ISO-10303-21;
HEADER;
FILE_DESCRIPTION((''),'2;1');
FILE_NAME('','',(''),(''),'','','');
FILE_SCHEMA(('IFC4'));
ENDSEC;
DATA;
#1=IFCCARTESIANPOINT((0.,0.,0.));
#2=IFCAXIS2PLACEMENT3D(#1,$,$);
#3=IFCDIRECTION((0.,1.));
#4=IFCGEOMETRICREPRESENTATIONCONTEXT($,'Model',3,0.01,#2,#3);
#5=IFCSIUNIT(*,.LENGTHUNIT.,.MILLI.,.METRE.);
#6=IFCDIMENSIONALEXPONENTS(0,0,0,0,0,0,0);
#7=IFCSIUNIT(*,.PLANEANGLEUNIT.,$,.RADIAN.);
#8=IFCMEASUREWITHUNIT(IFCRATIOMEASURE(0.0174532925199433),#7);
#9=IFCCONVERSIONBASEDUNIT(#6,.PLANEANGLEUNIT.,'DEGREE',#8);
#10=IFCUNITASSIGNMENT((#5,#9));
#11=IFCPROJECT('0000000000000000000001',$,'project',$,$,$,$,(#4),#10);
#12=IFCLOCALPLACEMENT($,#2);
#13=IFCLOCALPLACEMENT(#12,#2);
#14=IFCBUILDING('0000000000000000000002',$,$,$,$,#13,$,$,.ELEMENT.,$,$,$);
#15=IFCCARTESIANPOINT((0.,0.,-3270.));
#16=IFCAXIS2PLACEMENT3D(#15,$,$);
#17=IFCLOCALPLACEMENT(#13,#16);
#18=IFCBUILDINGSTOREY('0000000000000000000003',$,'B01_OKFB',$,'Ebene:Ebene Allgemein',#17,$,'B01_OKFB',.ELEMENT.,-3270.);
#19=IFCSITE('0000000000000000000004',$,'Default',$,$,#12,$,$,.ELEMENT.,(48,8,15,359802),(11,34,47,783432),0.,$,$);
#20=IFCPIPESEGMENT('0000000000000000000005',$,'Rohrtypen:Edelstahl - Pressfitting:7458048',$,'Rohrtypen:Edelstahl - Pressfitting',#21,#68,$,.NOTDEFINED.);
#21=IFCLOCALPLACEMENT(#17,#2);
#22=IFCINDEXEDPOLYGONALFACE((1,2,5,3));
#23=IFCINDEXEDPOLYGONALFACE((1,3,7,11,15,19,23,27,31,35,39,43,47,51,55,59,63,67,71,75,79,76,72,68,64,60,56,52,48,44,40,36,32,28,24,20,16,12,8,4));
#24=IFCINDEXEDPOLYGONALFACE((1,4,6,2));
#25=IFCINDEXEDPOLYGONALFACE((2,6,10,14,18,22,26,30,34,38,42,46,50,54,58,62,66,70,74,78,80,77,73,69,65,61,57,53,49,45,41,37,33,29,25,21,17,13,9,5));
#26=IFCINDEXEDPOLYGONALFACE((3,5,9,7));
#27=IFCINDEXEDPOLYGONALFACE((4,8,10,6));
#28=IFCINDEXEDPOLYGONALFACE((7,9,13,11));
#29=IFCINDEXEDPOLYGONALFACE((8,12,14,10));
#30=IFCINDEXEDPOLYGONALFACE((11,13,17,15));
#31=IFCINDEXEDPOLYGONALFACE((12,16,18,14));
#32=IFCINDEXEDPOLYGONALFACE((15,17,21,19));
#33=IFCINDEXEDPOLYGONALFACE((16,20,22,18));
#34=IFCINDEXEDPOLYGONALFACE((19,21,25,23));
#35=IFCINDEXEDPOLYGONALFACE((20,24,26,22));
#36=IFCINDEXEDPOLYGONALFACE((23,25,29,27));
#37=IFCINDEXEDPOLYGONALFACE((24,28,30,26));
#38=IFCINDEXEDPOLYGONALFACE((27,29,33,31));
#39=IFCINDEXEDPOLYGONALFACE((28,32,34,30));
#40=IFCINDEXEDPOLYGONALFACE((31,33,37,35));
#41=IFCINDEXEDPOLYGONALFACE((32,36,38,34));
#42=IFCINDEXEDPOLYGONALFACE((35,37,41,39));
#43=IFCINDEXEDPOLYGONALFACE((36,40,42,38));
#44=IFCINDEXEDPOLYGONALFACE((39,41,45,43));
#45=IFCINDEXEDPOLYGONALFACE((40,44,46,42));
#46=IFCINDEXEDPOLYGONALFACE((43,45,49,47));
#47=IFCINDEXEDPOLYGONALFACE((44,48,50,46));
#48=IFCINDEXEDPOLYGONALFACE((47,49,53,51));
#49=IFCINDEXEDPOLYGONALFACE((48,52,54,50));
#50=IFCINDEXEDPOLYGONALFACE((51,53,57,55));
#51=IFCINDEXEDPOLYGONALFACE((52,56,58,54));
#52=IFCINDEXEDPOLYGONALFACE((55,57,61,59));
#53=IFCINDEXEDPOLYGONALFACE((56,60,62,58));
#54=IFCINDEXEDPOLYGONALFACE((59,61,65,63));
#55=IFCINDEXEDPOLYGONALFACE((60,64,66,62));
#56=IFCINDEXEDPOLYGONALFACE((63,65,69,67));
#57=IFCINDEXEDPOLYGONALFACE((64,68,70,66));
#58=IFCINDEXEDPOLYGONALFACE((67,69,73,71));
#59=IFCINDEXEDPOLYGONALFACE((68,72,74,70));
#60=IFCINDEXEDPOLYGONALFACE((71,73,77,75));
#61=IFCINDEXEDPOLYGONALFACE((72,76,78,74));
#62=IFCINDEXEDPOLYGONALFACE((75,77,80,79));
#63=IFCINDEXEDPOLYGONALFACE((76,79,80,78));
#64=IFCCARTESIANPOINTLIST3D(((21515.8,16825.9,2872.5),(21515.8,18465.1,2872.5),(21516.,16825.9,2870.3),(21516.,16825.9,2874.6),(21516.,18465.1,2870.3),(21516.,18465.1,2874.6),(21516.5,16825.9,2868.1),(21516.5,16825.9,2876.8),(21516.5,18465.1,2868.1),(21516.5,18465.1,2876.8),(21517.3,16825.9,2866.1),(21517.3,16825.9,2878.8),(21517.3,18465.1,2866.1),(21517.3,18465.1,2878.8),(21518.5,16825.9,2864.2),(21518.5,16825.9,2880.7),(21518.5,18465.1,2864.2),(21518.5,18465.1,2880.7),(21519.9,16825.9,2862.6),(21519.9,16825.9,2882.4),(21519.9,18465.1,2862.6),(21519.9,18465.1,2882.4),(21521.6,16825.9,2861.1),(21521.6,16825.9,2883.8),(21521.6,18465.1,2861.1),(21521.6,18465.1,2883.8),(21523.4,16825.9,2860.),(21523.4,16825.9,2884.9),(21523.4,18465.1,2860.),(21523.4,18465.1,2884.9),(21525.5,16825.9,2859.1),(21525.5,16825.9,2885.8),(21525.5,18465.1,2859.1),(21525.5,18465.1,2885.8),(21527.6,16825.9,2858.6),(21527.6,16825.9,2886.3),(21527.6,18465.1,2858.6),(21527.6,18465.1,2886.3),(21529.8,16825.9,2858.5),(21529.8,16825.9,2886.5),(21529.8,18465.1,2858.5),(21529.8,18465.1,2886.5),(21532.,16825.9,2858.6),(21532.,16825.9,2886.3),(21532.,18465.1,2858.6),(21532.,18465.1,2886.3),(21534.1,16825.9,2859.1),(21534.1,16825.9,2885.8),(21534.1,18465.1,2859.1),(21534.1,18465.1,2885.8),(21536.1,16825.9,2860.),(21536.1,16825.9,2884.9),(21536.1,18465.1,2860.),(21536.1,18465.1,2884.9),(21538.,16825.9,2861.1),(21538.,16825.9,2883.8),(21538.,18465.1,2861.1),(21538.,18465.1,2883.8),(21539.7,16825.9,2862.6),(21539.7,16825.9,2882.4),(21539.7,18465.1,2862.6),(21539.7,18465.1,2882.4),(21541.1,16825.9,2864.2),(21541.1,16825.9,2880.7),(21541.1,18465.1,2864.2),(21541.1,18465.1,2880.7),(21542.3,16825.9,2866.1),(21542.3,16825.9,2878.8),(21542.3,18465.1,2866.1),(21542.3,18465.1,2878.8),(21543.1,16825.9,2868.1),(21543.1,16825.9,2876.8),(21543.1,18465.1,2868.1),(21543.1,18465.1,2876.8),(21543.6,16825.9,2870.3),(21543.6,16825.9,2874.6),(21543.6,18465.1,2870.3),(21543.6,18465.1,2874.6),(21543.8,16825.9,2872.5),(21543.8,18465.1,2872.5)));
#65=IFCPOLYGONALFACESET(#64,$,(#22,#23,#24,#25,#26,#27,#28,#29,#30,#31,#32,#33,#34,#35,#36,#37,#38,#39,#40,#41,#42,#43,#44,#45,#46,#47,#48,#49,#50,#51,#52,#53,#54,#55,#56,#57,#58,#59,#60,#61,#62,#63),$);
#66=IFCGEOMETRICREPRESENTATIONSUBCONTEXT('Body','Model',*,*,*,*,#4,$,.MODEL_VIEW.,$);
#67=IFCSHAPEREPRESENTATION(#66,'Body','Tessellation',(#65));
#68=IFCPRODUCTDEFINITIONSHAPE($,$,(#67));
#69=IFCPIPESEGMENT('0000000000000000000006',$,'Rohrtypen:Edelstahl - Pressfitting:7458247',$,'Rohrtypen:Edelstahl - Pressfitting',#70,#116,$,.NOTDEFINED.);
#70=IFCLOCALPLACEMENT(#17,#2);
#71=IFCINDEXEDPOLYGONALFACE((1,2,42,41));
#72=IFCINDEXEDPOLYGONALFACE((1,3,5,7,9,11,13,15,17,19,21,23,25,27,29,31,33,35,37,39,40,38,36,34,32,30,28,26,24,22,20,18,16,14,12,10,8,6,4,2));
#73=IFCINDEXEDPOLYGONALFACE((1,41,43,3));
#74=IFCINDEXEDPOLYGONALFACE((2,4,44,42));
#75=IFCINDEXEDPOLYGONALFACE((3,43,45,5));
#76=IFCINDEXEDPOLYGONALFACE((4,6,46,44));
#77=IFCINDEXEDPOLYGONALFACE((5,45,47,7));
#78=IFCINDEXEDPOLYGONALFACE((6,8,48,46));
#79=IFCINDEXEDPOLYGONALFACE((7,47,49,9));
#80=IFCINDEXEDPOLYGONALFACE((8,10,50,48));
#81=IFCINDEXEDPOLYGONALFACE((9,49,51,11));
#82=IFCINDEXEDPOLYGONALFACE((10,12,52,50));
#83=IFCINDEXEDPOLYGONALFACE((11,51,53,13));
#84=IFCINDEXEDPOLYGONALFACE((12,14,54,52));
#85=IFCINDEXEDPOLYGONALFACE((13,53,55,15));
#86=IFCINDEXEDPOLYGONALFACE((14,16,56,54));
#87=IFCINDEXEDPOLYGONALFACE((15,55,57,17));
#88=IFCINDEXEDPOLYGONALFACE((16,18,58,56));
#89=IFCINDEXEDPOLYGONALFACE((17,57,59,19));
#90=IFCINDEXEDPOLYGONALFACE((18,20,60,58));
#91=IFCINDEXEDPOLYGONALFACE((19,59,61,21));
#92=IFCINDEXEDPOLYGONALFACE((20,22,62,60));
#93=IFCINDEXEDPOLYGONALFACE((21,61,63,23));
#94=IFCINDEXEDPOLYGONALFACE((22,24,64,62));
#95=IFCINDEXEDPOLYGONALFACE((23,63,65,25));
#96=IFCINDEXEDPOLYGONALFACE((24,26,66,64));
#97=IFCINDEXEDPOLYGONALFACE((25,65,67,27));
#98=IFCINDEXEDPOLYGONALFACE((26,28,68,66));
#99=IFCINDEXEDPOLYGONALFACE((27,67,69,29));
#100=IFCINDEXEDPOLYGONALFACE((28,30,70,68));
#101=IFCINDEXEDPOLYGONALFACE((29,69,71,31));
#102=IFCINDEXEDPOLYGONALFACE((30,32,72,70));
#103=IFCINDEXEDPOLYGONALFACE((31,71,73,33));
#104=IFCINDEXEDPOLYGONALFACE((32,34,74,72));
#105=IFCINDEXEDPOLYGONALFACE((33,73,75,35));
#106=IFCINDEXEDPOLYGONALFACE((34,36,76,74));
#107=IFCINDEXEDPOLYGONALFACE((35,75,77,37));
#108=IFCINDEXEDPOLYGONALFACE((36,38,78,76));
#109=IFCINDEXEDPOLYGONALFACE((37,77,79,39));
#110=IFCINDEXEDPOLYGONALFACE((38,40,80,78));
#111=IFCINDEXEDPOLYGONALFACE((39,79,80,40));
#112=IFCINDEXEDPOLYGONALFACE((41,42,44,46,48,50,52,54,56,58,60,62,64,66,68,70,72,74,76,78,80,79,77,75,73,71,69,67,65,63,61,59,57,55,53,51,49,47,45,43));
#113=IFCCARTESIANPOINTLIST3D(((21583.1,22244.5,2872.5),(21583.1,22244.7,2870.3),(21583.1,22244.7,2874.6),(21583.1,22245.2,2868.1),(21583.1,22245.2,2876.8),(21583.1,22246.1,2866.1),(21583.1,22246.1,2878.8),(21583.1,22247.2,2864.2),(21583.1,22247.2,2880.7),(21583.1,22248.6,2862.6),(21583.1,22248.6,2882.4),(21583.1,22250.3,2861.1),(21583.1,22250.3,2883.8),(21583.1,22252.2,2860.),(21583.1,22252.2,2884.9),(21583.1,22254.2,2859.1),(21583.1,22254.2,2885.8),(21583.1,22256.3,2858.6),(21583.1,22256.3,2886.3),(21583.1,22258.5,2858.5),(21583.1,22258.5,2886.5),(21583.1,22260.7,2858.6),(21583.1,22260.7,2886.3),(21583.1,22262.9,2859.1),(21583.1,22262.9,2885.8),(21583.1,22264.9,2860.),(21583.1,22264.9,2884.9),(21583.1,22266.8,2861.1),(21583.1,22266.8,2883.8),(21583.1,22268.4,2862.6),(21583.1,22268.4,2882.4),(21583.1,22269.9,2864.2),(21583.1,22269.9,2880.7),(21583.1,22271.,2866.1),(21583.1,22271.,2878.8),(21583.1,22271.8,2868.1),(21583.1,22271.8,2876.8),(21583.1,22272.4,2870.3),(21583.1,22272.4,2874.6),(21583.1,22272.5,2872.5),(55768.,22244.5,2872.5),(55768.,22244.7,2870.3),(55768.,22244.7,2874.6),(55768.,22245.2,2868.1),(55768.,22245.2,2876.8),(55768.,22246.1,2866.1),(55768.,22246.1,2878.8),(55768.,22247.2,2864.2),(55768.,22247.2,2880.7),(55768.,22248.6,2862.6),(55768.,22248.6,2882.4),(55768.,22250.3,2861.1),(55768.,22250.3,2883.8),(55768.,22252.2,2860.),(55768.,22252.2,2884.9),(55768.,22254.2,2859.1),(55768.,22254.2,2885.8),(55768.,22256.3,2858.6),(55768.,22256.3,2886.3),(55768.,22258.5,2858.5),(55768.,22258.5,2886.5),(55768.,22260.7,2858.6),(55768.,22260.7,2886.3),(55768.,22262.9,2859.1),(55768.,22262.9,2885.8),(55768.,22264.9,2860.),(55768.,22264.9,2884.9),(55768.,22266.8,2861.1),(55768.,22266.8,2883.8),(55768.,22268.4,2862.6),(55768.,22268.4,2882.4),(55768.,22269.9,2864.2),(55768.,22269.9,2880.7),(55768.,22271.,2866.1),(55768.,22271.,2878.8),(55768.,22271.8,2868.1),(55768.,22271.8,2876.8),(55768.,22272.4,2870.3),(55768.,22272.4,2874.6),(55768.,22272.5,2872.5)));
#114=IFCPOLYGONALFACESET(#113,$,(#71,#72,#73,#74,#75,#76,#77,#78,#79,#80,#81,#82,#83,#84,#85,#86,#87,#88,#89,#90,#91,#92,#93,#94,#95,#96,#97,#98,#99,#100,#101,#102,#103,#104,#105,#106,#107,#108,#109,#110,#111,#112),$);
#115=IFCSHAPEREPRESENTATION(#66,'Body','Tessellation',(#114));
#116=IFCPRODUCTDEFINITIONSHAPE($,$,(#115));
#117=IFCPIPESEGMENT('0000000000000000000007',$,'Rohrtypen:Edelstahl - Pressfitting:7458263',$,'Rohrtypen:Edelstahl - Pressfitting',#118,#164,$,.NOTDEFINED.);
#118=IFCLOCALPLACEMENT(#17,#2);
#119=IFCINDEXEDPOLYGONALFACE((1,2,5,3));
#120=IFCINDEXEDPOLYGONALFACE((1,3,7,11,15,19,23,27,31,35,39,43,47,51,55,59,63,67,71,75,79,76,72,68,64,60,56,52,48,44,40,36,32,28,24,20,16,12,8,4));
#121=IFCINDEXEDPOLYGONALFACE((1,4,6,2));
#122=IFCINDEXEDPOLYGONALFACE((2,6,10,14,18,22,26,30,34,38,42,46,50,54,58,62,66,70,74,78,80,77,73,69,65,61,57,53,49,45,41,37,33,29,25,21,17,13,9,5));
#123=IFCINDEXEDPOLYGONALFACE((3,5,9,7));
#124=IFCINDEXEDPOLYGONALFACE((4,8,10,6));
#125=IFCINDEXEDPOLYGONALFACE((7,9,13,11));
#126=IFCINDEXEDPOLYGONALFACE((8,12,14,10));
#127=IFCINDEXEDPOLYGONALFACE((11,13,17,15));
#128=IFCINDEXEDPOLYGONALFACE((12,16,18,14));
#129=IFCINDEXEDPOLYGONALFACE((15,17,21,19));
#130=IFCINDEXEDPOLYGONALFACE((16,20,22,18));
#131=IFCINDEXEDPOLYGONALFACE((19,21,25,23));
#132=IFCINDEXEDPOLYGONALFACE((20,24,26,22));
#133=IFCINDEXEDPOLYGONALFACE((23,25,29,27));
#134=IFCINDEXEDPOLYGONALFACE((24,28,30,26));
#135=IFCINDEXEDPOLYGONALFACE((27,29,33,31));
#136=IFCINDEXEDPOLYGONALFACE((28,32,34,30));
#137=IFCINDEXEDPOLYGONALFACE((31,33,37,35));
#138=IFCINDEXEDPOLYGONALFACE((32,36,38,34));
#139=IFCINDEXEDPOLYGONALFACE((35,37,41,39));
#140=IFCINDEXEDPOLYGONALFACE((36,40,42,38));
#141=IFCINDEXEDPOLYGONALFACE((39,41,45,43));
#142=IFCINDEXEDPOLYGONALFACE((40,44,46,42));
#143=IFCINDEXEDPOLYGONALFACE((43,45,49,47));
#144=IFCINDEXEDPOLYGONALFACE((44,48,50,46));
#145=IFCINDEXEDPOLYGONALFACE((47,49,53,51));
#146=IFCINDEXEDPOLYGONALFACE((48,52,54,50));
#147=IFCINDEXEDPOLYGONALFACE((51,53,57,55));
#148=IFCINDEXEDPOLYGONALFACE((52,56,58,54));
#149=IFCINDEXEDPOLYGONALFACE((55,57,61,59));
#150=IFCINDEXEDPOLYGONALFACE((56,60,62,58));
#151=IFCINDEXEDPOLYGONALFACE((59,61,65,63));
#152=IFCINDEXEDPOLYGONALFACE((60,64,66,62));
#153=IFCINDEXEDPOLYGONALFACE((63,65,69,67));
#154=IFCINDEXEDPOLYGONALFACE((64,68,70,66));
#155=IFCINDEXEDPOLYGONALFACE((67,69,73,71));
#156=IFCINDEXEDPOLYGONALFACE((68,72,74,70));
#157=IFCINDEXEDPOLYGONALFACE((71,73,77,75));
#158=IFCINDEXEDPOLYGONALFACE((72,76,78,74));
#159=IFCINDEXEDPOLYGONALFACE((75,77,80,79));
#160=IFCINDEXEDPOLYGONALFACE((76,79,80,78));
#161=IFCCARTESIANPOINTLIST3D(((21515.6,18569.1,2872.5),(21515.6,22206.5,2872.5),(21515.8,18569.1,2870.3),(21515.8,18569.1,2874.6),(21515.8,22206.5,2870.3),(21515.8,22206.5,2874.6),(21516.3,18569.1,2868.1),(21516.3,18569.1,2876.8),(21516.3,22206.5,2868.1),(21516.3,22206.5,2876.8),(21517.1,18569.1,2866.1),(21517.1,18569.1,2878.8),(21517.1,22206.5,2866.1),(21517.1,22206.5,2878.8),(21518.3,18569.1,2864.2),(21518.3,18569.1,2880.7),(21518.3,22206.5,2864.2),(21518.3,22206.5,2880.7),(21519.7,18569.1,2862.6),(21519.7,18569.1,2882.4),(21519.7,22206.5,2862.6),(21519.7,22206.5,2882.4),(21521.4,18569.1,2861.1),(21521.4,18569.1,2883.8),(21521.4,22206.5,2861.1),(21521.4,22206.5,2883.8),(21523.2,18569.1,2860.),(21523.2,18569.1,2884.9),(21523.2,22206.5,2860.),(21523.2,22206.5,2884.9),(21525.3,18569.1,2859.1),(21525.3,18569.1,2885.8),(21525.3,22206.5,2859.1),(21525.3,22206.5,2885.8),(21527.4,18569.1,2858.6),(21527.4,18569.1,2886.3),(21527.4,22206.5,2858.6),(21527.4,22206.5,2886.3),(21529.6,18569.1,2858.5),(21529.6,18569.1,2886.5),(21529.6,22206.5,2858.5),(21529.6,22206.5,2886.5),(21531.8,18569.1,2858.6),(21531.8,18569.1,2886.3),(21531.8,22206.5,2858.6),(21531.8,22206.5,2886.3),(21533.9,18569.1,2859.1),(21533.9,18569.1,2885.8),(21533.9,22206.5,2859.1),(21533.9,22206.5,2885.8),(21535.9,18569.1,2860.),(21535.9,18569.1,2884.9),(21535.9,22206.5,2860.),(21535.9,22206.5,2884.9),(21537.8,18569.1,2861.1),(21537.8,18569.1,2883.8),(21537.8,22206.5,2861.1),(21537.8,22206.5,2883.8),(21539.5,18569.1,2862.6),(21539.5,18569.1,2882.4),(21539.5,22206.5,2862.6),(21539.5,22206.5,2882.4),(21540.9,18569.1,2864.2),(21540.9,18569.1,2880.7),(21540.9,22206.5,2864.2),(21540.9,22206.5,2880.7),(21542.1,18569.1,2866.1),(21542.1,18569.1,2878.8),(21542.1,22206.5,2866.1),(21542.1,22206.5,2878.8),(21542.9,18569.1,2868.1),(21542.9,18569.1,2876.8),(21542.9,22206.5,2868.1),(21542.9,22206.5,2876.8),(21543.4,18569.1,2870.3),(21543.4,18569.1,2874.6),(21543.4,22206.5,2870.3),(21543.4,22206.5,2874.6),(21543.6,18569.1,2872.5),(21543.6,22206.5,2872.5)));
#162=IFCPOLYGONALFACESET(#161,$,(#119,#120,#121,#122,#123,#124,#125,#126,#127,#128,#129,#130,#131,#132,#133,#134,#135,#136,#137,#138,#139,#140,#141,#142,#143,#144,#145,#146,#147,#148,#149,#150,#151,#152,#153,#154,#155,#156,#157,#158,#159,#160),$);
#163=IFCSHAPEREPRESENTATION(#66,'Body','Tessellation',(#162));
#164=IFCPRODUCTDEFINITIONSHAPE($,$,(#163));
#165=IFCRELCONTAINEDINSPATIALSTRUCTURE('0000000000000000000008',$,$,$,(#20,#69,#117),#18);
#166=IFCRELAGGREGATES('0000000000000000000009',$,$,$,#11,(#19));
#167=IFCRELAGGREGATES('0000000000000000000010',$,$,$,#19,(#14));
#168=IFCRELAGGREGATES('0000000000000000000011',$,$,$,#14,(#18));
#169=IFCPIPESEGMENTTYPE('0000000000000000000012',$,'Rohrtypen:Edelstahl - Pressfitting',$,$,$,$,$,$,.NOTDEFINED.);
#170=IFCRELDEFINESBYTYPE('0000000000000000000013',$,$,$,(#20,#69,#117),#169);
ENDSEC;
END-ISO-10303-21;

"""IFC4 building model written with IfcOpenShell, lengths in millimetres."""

from ifc_helpers import new_model, entity, si_unit, converted_unit, direction, frame, origin, place, context, subcontext, project, spatial, indexed_curve, outline, extrude, type_object, element, save


model = new_model("IFC4")

# Units and contexts
model_context = context("Model", 3, precision=0.01, world=origin(), true_north=direction((0.0, 1.0)))
body_context = subcontext(model_context, "Body", "Model", "MODEL_VIEW")
ifc_project = project(units=[si_unit("LENGTHUNIT", "METRE", prefix="MILLI"), converted_unit("PLANEANGLEUNIT", "DEGREE", entity("IfcRatioMeasure", 0.0174532925199433), si_unit("PLANEANGLEUNIT", "RADIAN"), dimensions=[0, 0, 0, 0, 0, 0, 0])], contexts=[model_context])

# Site, building, storey
site_placement = place(None, origin())
site = spatial("IfcSite", under=ifc_project, at=site_placement, Name="Default", CompositionType="ELEMENT", RefLatitude=(48, 8, 15, 359802), RefLongitude=(11, 34, 47, 783432), RefElevation=0.0)
building_placement = place(site_placement, origin())
building = spatial("IfcBuilding", under=site, at=building_placement, CompositionType="ELEMENT")
storey_placement = place(building_placement, frame((0.0, 0.0, -3270.0)))
storey = spatial("IfcBuildingStorey", under=building, at=storey_placement, Name="B01_OKFB", ObjectType="Ebene:Ebene Allgemein", LongName="B01_OKFB", CompositionType="ELEMENT", Elevation=-3270.0)

# Pipe segments
pipe_segment_type_1 = type_object("IfcPipeSegmentType", Name="Rohrtypen:Edelstahl - Pressfitting", PredefinedType="NOTDEFINED")
pipe_segment_1_placement = place(storey_placement, origin())
element("IfcPipeSegment", 1, at=pipe_segment_1_placement, inside=storey, type_object=pipe_segment_type_1, Name="Rohrtypen:Edelstahl - Pressfitting:7458048", ObjectType="Rohrtypen:Edelstahl - Pressfitting", PredefinedType="NOTDEFINED", context=body_context, shape_type="SweptSolid", body=[
    extrude(outline(indexed_curve([(14.0, 0.0), (13.8, 2.2), (13.3, 4.3), (12.5, 6.4), (11.3, 8.2), (9.9, 9.9), (8.2, 11.3), (6.4, 12.5), (4.3, 13.3), (2.2, 13.8), (0.0, 14.0), (-2.2, 13.8), (-4.3, 13.3), (-6.4, 12.5), (-8.2, 11.3), (-9.9, 9.9), (-11.3, 8.2), (-12.5, 6.4), (-13.3, 4.3), (-13.8, 2.2), (-14.0, 0.0), (-13.8, -2.2), (-13.3, -4.3), (-12.5, -6.4), (-11.3, -8.2), (-9.9, -9.9), (-8.2, -11.3), (-6.4, -12.5), (-4.3, -13.3), (-2.2, -13.8), (0.0, -14.0), (2.2, -13.8), (4.3, -13.3), (6.4, -12.5), (8.2, -11.3), (9.9, -9.9), (11.3, -8.2), (12.5, -6.4), (13.3, -4.3), (13.8, -2.2), (14.0, 0.0)], self_intersect=False)), frame((21529.8, 16825.9, 2872.5), z_axis=(0.0, 1.0, 0.0), x_axis=(1.0, 0.0, 0.0)), (0.0, 0.0, 1.0), 1639.2),
])
pipe_segment_2_placement = place(storey_placement, origin())
element("IfcPipeSegment", 2, at=pipe_segment_2_placement, inside=storey, type_object=pipe_segment_type_1, Name="Rohrtypen:Edelstahl - Pressfitting:7458247", ObjectType="Rohrtypen:Edelstahl - Pressfitting", PredefinedType="NOTDEFINED", context=body_context, shape_type="SweptSolid", body=[
    extrude(outline(indexed_curve([(14.0, 0.0), (13.8, 2.2), (13.3, 4.3), (12.5, 6.4), (11.3, 8.2), (9.9, 9.9), (8.2, 11.3), (6.4, 12.5), (4.3, 13.3), (2.2, 13.8), (0.0, 14.0), (-2.2, 13.8), (-4.3, 13.3), (-6.4, 12.5), (-8.2, 11.3), (-9.9, 9.9), (-11.3, 8.2), (-12.5, 6.4), (-13.3, 4.3), (-13.8, 2.2), (-14.0, 0.0), (-13.8, -2.2), (-13.3, -4.3), (-12.5, -6.4), (-11.3, -8.2), (-9.9, -9.9), (-8.2, -11.3), (-6.4, -12.5), (-4.3, -13.3), (-2.2, -13.8), (0.0, -14.0), (2.2, -13.8), (4.3, -13.3), (6.4, -12.5), (8.2, -11.3), (9.9, -9.9), (11.3, -8.2), (12.5, -6.4), (13.3, -4.3), (13.8, -2.2), (14.0, 0.0)], self_intersect=False)), frame((21583.1, 22258.5, 2872.5), z_axis=(1.0, 0.0, 0.0), x_axis=(0.0, -1.0, 0.0)), (0.0, 0.0, 1.0), 34184.9),
])
pipe_segment_3_placement = place(storey_placement, origin())
element("IfcPipeSegment", 3, at=pipe_segment_3_placement, inside=storey, type_object=pipe_segment_type_1, Name="Rohrtypen:Edelstahl - Pressfitting:7458263", ObjectType="Rohrtypen:Edelstahl - Pressfitting", PredefinedType="NOTDEFINED", context=body_context, shape_type="SweptSolid", body=[
    extrude(outline(indexed_curve([(14.0, 0.0), (13.8, 2.2), (13.3, 4.3), (12.5, 6.4), (11.3, 8.2), (9.9, 9.9), (8.2, 11.3), (6.4, 12.5), (4.3, 13.3), (2.2, 13.8), (0.0, 14.0), (-2.2, 13.8), (-4.3, 13.3), (-6.4, 12.5), (-8.2, 11.3), (-9.9, 9.9), (-11.3, 8.2), (-12.5, 6.4), (-13.3, 4.3), (-13.8, 2.2), (-14.0, 0.0), (-13.8, -2.2), (-13.3, -4.3), (-12.5, -6.4), (-11.3, -8.2), (-9.9, -9.9), (-8.2, -11.3), (-6.4, -12.5), (-4.3, -13.3), (-2.2, -13.8), (0.0, -14.0), (2.2, -13.8), (4.3, -13.3), (6.4, -12.5), (8.2, -11.3), (9.9, -9.9), (11.3, -8.2), (12.5, -6.4), (13.3, -4.3), (13.8, -2.2), (14.0, 0.0)], self_intersect=False)), frame((21529.6, 18569.1, 2872.5), z_axis=(0.0, 1.0, 0.0), x_axis=(1.0, 0.0, 0.0)), (0.0, 0.0, 1.0), 3637.4),
])

save(model, "model.ifc")
